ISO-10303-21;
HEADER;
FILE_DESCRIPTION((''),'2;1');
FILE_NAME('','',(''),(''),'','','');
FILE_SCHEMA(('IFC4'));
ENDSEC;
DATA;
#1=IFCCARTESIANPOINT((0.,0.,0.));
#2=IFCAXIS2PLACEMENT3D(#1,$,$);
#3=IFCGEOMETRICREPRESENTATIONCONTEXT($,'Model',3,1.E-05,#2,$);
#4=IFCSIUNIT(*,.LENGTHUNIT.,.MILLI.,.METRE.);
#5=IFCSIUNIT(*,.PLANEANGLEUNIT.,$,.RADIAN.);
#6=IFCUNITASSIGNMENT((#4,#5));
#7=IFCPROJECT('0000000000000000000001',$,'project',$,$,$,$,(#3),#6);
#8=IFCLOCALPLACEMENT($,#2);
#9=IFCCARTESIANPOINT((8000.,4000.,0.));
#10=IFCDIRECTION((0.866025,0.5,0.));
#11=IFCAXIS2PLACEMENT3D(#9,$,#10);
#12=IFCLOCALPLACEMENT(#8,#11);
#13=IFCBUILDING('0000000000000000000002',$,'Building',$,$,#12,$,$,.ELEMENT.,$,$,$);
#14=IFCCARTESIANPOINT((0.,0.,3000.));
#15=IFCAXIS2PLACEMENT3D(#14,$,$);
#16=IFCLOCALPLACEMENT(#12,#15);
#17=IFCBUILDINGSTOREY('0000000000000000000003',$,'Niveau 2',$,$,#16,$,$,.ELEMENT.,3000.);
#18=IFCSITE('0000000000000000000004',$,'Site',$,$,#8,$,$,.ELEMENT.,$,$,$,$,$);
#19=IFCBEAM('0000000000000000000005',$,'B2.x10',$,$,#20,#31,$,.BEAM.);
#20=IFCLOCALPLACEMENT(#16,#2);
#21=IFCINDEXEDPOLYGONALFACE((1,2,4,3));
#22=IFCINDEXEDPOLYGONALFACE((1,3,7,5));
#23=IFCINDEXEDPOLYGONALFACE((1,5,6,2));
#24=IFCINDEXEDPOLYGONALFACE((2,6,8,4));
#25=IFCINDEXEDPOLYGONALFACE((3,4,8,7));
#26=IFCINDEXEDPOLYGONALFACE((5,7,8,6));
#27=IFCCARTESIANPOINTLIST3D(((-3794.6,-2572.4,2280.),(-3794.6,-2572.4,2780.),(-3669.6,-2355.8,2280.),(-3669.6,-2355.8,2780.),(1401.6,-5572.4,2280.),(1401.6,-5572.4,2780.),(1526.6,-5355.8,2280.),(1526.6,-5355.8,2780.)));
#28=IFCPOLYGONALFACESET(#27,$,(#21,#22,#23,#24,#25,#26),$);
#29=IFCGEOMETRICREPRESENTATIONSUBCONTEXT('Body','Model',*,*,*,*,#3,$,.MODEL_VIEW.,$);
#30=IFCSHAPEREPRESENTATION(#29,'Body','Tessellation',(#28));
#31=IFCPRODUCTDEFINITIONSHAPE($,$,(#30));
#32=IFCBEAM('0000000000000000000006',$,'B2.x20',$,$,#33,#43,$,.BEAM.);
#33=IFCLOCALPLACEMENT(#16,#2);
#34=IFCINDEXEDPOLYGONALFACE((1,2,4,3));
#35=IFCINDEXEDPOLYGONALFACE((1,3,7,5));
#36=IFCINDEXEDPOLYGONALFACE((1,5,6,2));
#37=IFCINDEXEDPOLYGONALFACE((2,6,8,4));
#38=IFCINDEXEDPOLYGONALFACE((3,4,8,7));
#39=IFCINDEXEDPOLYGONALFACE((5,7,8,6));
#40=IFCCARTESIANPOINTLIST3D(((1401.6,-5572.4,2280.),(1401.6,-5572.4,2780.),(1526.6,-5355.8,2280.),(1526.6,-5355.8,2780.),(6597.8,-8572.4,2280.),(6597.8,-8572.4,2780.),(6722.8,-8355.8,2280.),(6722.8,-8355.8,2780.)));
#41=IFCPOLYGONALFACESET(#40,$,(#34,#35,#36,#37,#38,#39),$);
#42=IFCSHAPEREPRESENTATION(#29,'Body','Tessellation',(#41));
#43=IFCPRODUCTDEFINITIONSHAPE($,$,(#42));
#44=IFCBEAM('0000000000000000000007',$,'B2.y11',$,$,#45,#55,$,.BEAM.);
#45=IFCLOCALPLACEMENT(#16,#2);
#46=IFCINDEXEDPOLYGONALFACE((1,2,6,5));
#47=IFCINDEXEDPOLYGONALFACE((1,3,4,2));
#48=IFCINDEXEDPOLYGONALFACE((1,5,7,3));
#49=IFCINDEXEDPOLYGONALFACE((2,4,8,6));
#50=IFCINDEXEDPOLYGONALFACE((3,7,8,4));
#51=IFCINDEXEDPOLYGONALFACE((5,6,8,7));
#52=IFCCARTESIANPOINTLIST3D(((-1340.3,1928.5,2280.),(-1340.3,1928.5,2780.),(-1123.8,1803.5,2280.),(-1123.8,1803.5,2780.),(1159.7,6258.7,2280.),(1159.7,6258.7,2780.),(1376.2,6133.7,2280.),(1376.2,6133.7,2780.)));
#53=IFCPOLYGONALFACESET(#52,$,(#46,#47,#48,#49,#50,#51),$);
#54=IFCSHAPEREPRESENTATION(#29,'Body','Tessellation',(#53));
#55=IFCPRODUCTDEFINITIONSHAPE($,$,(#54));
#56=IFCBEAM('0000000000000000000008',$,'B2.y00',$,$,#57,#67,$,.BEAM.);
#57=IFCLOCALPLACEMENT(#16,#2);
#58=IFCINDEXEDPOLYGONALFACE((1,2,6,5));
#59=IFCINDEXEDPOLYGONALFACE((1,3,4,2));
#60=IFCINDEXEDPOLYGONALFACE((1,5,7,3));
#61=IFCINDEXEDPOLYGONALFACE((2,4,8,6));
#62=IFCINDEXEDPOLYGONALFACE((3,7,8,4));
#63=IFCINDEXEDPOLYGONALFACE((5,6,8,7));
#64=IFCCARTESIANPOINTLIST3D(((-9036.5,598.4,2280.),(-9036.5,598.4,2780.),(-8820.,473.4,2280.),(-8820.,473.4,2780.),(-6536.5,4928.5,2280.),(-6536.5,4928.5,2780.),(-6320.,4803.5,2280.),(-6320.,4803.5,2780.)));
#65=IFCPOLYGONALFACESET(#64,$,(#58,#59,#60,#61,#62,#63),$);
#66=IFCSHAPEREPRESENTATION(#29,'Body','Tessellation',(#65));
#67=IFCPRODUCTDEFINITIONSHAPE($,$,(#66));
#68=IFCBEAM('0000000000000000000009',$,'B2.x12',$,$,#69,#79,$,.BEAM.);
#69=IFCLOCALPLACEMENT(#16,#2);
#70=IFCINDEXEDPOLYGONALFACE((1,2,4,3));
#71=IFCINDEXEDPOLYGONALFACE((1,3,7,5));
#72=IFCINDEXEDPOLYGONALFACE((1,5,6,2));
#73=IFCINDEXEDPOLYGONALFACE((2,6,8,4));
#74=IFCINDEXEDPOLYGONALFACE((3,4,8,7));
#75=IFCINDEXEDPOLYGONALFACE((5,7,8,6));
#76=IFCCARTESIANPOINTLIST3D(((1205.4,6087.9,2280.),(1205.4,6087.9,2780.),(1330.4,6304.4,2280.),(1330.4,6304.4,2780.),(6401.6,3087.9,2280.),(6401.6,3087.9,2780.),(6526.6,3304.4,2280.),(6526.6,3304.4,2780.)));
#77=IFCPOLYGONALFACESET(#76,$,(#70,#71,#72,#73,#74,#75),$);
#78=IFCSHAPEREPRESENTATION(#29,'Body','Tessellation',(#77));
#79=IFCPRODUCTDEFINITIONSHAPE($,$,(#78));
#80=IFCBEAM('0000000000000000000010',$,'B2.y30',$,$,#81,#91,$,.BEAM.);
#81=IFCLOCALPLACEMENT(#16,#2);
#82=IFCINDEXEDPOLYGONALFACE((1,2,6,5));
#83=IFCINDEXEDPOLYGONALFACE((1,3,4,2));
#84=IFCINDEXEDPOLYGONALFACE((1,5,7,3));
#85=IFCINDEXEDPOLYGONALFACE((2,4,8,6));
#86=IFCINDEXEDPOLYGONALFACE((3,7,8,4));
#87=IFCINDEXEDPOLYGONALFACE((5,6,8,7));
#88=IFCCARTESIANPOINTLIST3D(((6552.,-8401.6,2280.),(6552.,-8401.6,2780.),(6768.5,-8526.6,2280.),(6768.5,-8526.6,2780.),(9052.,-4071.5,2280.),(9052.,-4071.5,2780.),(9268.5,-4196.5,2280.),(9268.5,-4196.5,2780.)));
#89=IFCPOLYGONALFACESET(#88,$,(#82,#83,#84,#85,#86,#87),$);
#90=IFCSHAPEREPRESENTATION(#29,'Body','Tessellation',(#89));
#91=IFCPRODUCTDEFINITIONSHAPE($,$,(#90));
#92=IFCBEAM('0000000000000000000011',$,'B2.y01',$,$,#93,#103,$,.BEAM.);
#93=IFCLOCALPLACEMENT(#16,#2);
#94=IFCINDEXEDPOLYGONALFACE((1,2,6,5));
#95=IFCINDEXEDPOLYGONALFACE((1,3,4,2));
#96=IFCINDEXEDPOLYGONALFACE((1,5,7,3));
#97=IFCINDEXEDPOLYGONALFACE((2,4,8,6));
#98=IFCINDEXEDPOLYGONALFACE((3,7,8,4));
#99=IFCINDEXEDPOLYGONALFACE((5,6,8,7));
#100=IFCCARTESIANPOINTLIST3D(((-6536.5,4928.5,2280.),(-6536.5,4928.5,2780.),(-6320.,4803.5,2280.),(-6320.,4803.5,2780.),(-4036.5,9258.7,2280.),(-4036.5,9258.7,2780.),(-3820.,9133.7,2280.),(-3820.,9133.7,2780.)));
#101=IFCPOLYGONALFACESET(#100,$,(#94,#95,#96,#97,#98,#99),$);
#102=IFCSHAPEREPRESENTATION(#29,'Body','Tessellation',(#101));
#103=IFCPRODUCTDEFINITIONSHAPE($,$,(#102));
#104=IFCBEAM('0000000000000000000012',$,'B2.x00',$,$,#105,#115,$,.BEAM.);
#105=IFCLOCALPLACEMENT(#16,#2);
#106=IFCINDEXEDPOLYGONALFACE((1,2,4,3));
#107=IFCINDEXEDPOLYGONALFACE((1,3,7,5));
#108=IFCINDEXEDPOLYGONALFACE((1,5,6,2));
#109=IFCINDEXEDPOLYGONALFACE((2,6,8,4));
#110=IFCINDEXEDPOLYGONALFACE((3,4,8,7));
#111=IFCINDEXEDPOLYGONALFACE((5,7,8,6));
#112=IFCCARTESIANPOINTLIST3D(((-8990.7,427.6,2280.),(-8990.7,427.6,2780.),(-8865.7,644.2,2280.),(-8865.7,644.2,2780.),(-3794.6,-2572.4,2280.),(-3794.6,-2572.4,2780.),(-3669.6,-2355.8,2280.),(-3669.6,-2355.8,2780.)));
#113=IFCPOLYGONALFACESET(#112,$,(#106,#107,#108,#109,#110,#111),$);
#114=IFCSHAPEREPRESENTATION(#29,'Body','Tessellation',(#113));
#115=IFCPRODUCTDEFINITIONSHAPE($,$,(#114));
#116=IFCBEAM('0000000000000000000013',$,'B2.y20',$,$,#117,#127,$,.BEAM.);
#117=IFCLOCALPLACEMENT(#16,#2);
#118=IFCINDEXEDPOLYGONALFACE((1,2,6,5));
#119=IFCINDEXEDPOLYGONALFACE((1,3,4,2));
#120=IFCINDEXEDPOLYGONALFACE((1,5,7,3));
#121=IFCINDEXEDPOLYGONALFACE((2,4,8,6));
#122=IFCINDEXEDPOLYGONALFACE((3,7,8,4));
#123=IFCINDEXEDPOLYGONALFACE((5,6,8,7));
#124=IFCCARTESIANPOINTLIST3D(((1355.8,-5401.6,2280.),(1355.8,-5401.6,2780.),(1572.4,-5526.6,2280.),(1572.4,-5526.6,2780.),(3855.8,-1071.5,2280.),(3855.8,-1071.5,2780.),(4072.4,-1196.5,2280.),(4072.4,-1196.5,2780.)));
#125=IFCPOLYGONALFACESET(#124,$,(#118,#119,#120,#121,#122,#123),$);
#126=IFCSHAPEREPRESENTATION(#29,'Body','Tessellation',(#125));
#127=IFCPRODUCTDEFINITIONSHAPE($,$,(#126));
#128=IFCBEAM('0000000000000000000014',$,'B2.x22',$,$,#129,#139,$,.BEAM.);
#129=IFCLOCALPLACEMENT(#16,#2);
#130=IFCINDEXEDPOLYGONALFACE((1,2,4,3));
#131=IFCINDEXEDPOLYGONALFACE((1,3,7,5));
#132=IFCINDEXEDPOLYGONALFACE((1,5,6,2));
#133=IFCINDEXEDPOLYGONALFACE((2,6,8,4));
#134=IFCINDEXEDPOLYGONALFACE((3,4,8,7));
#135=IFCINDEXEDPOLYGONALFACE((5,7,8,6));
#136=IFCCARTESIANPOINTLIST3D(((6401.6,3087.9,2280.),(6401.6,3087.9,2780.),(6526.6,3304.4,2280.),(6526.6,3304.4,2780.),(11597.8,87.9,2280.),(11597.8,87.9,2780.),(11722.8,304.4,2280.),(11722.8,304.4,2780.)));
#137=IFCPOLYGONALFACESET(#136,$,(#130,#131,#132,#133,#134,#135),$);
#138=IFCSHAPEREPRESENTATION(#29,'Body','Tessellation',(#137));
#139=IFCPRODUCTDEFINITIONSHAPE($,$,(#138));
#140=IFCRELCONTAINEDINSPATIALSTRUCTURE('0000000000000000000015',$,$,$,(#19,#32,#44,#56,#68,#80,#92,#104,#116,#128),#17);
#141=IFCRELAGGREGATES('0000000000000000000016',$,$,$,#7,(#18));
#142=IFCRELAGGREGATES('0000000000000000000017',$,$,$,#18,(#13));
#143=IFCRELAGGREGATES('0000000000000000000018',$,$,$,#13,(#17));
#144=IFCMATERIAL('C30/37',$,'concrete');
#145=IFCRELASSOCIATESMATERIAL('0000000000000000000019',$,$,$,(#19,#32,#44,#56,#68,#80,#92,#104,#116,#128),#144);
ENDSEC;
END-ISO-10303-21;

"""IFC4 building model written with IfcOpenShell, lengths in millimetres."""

from ifc_helpers import new_model, si_unit, frame, origin, place, context, subcontext, project, spatial, rectangle, extrude, material, element, save


model = new_model("IFC4")

# Units and contexts
model_context = context("Model", 3, precision=1e-05, world=origin())
body_context = subcontext(model_context, "Body", "Model", "MODEL_VIEW")
ifc_project = project(units=[si_unit("LENGTHUNIT", "METRE", prefix="MILLI"), si_unit("PLANEANGLEUNIT", "RADIAN")], contexts=[model_context])

# Site, building, storey
site_placement = place(None, origin())
site = spatial("IfcSite", under=ifc_project, at=site_placement, Name="Site", CompositionType="ELEMENT")
building_placement = place(site_placement, frame((8000.0, 4000.0, 0.0), x_axis=(0.866025, 0.5, 0.0)))
building = spatial("IfcBuilding", under=site, at=building_placement, Name="Building", CompositionType="ELEMENT")
storey_placement = place(building_placement, frame((0.0, 0.0, 3000.0)))
storey = spatial("IfcBuildingStorey", under=building, at=storey_placement, Name="Niveau 2", CompositionType="ELEMENT", Elevation=3000.0)

# Shared definitions
ifc_material = material(Name="C30/37", Category="concrete")

# Beams
for number, where, z_axis, x_axis, name in (
    (1, (-3732.1, -2464.1, 2530.0), (0.866025, -0.5, 0.0), (0.5, 0.866025, 0.0), "B2.x10"),
    (2, (1464.1, -5464.1, 2530.0), (0.866025, -0.5, 0.0), (0.5, 0.866025, 0.0), "B2.x20"),
):
    element("IfcBeam", number, at=place(storey_placement, frame(where, z_axis=z_axis, x_axis=x_axis)), inside=storey, material=ifc_material, Name=name, PredefinedType="BEAM", context=body_context, shape_type="SweptSolid", body=[
        extrude(rectangle(XDim=250.0, YDim=500.0), origin(), (0.0, 0.0, 1.0), 6000.0),
    ])
for number, where, z_axis, x_axis, name in (
    (3, (-1232.1, 1866.0, 2530.0), (0.5, 0.866025, 0.0), (-0.866025, 0.5, 0.0), "B2.y11"),
    (4, (-8928.2, 535.9, 2530.0), (0.5, 0.866025, 0.0), (-0.866025, 0.5, 0.0), "B2.y00"),
):
    element("IfcBeam", number, at=place(storey_placement, frame(where, z_axis=z_axis, x_axis=x_axis)), inside=storey, material=ifc_material, Name=name, PredefinedType="BEAM", context=body_context, shape_type="SweptSolid", body=[
        extrude(rectangle(XDim=250.0, YDim=500.0), origin(), (0.0, 0.0, 1.0), 5000.0),
    ])
beam_1_placement = place(storey_placement, frame((1267.9, 6196.2, 2530.0), z_axis=(0.866025, -0.5, 0.0), x_axis=(0.5, 0.866025, 0.0)))
element("IfcBeam", 5, at=beam_1_placement, inside=storey, material=ifc_material, Name="B2.x12", PredefinedType="BEAM", context=body_context, shape_type="SweptSolid", body=[
    extrude(rectangle(XDim=250.0, YDim=500.0), origin(), (0.0, 0.0, 1.0), 6000.0),
])
for number, where, z_axis, x_axis, name in (
    (6, (6660.3, -8464.1, 2530.0), (0.5, 0.866025, 0.0), (-0.866025, 0.5, 0.0), "B2.y30"),
    (7, (-6428.2, 4866.0, 2530.0), (0.5, 0.866025, 0.0), (-0.866025, 0.5, 0.0), "B2.y01"),
):
    element("IfcBeam", number, at=place(storey_placement, frame(where, z_axis=z_axis, x_axis=x_axis)), inside=storey, material=ifc_material, Name=name, PredefinedType="BEAM", context=body_context, shape_type="SweptSolid", body=[
        extrude(rectangle(XDim=250.0, YDim=500.0), origin(), (0.0, 0.0, 1.0), 5000.0),
    ])
beam_2_placement = place(storey_placement, frame((-8928.2, 535.9, 2530.0), z_axis=(0.866025, -0.5, 0.0), x_axis=(0.5, 0.866025, 0.0)))
element("IfcBeam", 8, at=beam_2_placement, inside=storey, material=ifc_material, Name="B2.x00", PredefinedType="BEAM", context=body_context, shape_type="SweptSolid", body=[
    extrude(rectangle(XDim=250.0, YDim=500.0), origin(), (0.0, 0.0, 1.0), 6000.0),
])
beam_3_placement = place(storey_placement, frame((1464.1, -5464.1, 2530.0), z_axis=(0.5, 0.866025, 0.0), x_axis=(-0.866025, 0.5, 0.0)))
element("IfcBeam", 9, at=beam_3_placement, inside=storey, material=ifc_material, Name="B2.y20", PredefinedType="BEAM", context=body_context, shape_type="SweptSolid", body=[
    extrude(rectangle(XDim=250.0, YDim=500.0), origin(), (0.0, 0.0, 1.0), 5000.0),
])
beam_4_placement = place(storey_placement, frame((6464.1, 3196.2, 2530.0), z_axis=(0.866025, -0.5, 0.0), x_axis=(0.5, 0.866025, 0.0)))
element("IfcBeam", 10, at=beam_4_placement, inside=storey, material=ifc_material, Name="B2.x22", PredefinedType="BEAM", context=body_context, shape_type="SweptSolid", body=[
    extrude(rectangle(XDim=250.0, YDim=500.0), origin(), (0.0, 0.0, 1.0), 6000.0),
])

save(model, "model.ifc")
